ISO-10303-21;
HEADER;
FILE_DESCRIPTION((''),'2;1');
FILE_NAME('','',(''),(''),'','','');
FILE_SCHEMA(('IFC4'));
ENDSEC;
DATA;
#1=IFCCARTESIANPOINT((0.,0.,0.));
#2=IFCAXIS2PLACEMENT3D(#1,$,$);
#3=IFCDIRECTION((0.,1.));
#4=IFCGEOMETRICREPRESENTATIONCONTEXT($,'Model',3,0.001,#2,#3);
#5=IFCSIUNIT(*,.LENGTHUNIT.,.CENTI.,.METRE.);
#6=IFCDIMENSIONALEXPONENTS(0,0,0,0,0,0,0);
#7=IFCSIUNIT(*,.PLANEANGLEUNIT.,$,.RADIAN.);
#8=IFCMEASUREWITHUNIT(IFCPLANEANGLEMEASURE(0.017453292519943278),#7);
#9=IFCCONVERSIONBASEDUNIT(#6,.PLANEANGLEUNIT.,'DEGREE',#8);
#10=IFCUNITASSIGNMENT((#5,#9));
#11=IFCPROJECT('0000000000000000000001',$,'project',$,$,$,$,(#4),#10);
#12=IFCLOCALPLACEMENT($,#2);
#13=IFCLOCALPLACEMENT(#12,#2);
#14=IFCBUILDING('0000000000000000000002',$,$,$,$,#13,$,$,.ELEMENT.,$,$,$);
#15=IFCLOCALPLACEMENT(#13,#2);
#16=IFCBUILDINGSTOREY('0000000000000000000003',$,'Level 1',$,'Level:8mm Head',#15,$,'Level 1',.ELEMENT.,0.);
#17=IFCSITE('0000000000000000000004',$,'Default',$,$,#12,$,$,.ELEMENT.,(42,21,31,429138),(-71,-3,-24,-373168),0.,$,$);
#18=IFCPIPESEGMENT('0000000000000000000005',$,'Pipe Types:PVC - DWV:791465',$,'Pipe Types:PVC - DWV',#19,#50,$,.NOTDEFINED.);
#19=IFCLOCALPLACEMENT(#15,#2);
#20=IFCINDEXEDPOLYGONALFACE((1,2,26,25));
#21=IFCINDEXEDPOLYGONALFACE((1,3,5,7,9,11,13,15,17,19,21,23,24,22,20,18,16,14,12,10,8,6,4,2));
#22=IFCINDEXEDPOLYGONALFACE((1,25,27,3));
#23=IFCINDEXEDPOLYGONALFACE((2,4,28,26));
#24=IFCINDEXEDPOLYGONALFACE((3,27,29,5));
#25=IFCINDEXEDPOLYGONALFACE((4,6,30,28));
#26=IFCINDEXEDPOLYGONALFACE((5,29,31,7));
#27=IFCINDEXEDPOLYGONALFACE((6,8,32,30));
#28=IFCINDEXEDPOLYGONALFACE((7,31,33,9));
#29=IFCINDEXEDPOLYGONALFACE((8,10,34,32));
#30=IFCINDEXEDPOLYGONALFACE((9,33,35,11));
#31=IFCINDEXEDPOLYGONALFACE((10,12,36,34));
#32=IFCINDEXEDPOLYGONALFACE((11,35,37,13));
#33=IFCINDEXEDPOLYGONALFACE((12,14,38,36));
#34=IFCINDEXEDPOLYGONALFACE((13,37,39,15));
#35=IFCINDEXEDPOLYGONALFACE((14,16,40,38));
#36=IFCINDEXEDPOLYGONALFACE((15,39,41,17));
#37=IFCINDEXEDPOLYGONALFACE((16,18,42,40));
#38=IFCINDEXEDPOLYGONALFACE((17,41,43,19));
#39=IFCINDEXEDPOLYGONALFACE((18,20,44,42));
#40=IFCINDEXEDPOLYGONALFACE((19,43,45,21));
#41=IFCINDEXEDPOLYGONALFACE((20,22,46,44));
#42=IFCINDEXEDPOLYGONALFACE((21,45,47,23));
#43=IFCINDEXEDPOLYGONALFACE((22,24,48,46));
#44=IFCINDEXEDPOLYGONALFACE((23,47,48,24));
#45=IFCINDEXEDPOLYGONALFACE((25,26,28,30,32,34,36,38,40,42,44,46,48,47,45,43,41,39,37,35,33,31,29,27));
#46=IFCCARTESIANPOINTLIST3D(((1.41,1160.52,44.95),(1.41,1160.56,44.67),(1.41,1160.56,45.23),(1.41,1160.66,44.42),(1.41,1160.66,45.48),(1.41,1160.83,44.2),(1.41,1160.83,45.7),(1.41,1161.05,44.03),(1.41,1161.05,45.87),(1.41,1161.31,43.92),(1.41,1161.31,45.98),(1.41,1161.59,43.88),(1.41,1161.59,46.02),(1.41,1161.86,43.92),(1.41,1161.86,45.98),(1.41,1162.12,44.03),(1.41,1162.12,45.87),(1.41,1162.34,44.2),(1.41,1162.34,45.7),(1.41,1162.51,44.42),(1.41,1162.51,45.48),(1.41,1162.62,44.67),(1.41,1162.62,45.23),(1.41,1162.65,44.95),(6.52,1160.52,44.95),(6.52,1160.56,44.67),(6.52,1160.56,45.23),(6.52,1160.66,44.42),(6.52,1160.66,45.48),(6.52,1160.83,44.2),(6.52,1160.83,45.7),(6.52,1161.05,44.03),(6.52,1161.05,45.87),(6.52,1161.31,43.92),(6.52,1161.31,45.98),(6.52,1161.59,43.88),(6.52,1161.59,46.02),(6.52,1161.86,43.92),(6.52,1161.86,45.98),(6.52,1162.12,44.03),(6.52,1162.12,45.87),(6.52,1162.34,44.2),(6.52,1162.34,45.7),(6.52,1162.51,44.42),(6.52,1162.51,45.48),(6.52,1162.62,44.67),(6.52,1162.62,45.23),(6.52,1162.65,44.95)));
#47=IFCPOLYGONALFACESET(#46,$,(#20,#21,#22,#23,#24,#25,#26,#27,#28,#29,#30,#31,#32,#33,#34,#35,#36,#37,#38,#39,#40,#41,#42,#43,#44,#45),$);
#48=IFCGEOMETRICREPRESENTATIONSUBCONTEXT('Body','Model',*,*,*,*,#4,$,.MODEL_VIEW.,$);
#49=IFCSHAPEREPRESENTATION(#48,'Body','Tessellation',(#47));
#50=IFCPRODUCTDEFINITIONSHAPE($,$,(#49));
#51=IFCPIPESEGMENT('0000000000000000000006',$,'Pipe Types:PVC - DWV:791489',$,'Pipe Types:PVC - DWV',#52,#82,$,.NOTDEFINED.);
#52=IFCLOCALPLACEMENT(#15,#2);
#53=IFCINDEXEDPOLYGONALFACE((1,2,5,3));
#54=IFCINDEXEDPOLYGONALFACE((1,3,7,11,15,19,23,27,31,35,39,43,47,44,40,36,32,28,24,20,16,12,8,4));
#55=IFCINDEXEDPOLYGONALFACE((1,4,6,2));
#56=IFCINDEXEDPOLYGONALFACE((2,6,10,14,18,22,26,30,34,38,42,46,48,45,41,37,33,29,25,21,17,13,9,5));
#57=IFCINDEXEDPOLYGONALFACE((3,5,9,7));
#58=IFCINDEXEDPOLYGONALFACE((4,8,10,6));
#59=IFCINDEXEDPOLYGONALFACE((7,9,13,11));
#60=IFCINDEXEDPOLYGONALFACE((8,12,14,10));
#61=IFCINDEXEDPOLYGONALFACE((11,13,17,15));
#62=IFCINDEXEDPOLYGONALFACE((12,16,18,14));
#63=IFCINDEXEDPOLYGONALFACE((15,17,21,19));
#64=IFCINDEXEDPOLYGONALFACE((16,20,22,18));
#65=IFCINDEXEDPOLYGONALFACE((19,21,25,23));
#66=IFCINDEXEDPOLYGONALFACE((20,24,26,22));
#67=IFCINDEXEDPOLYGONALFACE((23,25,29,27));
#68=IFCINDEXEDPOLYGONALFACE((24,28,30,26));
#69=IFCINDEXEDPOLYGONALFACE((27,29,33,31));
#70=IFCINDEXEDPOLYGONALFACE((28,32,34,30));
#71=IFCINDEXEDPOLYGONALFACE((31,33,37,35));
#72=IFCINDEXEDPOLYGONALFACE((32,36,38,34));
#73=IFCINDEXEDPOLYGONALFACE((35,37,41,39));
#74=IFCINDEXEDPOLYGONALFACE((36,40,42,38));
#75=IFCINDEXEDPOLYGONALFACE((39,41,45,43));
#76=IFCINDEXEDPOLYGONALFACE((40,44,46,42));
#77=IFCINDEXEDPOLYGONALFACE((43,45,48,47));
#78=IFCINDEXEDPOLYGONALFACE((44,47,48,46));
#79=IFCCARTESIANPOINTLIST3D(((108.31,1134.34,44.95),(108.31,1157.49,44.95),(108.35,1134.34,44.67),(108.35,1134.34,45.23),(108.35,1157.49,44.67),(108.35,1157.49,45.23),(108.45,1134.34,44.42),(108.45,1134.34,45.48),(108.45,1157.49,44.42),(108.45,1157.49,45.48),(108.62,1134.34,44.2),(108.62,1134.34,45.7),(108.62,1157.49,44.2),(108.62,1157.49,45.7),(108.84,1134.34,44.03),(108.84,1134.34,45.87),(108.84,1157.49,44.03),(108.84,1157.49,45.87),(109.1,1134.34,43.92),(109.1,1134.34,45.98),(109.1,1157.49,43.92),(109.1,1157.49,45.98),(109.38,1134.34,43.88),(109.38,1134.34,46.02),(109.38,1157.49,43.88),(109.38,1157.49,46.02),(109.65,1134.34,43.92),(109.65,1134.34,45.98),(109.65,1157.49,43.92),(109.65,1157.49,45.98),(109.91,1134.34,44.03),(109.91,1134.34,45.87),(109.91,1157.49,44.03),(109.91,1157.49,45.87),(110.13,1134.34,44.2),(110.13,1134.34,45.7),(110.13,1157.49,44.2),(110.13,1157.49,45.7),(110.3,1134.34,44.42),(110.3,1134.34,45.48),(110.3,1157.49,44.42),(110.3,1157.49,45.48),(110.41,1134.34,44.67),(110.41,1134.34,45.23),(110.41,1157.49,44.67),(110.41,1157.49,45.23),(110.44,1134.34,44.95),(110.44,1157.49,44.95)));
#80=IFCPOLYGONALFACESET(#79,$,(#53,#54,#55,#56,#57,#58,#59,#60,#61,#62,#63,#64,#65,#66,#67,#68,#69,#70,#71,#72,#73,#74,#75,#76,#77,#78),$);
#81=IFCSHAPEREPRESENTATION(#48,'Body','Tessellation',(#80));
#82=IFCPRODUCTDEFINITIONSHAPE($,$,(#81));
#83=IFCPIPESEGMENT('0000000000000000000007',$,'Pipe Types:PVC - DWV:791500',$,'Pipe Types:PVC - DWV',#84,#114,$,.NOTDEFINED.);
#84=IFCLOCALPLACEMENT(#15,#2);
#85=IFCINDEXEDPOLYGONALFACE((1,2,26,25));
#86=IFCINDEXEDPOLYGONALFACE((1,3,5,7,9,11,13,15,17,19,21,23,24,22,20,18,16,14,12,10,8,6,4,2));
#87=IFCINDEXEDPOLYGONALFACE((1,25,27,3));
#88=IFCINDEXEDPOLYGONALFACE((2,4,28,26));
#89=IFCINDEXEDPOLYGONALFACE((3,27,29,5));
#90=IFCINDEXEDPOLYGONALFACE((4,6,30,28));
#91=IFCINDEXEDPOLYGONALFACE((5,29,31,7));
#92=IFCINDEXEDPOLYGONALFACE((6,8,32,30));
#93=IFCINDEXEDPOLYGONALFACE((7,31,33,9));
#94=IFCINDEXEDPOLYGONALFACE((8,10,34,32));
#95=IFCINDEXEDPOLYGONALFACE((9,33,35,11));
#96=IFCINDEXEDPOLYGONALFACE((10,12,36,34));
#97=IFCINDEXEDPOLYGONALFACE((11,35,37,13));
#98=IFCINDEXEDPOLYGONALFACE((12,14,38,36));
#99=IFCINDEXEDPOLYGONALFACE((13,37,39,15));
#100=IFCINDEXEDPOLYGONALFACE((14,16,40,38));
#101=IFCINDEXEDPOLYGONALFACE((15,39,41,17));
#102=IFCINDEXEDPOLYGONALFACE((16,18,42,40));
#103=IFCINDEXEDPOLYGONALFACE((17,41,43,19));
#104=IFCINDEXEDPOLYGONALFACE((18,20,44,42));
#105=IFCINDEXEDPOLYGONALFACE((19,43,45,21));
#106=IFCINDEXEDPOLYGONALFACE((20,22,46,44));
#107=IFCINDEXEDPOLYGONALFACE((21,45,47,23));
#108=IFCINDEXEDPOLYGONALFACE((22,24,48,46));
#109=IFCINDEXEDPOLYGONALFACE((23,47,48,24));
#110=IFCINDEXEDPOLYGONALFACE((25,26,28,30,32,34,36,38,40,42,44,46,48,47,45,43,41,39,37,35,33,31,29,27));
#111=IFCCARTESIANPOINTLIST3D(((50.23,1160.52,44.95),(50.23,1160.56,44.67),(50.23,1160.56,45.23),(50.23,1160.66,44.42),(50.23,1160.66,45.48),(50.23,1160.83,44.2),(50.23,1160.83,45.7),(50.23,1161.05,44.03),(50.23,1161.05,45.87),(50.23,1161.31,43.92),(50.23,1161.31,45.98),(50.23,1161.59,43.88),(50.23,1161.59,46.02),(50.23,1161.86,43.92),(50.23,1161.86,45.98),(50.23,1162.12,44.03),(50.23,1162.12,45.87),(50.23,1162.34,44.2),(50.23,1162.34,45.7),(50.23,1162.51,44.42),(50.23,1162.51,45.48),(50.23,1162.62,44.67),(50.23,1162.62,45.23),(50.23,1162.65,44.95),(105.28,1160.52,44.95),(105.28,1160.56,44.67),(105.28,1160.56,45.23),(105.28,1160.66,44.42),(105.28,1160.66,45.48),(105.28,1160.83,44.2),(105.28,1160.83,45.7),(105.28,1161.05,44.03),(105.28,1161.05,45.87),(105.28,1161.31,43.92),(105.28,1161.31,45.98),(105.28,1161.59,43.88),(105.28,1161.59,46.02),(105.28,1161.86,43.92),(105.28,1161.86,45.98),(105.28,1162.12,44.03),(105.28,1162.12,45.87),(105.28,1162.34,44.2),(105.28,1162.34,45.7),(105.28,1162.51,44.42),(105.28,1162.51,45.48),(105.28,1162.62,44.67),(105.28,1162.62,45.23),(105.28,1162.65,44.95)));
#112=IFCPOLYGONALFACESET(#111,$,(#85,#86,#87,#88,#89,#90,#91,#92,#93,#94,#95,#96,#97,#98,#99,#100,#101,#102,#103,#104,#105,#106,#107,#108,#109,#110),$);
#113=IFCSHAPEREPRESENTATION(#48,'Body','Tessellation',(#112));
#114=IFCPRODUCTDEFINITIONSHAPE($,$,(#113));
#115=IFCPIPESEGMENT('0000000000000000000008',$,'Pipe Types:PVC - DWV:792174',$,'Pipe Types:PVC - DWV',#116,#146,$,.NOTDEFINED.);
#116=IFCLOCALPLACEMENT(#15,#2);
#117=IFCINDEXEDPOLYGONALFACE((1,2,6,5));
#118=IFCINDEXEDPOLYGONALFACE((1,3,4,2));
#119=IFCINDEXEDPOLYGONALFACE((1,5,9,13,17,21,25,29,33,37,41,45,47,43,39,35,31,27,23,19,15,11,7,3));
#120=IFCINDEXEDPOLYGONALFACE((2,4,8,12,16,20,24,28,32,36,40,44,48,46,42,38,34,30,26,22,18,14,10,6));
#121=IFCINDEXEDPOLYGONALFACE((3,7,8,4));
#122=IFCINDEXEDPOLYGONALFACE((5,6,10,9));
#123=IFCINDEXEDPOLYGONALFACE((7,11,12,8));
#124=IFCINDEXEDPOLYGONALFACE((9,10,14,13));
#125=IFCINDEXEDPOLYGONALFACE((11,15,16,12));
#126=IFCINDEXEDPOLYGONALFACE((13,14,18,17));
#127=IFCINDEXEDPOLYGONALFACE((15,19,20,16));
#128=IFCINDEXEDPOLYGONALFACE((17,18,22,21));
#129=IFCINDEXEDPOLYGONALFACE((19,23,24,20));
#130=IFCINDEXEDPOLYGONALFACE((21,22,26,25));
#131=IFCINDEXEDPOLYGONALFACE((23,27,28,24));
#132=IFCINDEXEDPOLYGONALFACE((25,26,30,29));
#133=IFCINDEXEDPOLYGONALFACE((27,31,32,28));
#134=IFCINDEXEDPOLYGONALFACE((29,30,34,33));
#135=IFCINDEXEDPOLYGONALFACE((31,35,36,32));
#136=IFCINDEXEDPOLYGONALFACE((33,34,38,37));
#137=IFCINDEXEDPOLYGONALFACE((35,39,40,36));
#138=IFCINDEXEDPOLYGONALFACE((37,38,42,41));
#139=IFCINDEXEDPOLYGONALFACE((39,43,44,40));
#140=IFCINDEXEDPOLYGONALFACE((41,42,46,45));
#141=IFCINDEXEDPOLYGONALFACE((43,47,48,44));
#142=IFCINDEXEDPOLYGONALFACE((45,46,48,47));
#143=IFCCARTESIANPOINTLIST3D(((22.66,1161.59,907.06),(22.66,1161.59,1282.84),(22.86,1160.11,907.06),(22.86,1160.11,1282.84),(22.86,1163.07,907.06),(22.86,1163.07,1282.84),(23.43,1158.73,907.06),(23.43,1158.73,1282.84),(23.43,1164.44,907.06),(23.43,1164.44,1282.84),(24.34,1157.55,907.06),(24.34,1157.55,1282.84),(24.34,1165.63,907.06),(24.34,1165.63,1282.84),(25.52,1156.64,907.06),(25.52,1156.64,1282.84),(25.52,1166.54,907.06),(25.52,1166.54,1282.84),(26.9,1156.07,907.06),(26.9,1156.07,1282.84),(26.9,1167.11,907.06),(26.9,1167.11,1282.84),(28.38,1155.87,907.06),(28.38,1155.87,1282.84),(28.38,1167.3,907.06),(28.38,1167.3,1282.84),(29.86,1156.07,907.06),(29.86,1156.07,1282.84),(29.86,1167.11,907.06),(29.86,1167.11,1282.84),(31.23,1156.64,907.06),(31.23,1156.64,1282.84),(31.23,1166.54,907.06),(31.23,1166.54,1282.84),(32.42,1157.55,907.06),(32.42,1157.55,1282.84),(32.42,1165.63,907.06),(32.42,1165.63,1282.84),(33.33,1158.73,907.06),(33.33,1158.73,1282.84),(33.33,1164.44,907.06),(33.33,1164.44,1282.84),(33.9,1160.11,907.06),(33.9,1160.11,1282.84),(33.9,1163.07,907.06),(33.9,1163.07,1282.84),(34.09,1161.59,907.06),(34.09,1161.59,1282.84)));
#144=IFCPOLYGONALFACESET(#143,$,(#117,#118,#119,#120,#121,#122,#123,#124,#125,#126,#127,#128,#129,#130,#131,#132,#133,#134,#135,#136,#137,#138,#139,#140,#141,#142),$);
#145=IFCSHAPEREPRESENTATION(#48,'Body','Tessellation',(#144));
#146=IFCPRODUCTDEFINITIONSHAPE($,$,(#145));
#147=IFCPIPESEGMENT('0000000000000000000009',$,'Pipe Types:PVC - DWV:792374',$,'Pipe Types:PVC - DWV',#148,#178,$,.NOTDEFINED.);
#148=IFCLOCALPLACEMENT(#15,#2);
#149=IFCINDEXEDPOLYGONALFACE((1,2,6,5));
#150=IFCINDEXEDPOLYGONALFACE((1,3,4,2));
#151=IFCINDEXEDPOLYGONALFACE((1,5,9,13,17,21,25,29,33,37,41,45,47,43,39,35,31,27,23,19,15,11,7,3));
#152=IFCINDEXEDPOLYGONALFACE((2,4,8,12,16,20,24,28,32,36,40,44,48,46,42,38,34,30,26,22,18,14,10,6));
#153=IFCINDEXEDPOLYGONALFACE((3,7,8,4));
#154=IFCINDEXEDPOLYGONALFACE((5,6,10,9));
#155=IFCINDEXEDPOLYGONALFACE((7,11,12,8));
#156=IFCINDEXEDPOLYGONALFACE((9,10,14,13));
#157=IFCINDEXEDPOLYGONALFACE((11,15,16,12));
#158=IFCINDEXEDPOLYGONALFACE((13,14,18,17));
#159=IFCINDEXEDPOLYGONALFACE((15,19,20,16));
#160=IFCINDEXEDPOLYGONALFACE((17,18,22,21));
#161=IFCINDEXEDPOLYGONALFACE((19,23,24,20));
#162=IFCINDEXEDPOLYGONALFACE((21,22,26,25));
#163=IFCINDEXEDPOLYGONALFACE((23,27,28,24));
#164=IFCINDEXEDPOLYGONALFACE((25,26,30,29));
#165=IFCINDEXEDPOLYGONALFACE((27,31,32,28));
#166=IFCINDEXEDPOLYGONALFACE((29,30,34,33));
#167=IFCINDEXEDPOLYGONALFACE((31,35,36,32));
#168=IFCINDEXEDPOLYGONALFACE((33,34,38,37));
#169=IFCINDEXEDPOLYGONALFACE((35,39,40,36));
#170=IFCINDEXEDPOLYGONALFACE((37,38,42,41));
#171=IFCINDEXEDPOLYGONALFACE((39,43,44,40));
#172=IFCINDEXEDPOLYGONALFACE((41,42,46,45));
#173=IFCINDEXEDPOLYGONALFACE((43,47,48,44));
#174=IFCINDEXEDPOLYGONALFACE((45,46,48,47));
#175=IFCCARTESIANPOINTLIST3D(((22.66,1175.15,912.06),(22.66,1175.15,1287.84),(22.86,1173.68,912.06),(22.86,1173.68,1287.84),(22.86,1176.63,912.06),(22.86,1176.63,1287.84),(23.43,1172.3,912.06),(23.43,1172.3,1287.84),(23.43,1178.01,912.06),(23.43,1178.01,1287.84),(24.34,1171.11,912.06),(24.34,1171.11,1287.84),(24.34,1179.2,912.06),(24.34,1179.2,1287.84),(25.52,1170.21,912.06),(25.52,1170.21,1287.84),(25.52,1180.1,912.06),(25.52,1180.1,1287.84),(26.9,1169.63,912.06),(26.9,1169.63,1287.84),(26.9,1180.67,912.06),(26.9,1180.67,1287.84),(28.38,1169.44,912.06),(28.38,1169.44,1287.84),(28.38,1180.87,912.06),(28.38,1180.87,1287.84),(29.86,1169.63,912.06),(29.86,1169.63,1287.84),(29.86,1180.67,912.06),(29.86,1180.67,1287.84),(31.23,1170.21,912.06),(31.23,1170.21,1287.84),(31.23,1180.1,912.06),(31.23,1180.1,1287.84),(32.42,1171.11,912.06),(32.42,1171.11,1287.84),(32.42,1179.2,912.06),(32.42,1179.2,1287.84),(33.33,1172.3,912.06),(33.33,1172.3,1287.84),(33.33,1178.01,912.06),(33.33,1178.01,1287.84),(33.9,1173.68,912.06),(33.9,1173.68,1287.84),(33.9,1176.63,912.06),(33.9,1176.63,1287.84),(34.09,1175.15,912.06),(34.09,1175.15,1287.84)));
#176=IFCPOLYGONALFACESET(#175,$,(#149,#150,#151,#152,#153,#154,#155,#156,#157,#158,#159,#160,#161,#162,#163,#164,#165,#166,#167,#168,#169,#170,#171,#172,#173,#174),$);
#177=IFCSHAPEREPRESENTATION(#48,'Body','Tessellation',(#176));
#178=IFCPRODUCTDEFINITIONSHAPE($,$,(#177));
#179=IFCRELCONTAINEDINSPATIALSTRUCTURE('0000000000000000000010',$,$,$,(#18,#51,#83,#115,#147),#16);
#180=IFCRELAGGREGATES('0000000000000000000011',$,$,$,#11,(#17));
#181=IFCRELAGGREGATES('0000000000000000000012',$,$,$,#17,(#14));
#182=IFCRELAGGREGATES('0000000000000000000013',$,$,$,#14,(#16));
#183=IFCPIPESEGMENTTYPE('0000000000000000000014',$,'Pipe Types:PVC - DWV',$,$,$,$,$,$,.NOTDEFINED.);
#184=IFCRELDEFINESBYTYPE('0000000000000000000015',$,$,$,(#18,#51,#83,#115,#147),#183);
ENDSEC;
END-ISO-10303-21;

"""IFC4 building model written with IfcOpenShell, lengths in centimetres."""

from ifc_helpers import new_model, entity, si_unit, converted_unit, direction, frame, origin, place, context, subcontext, project, spatial, arc, indexed_curve, outline, extrude, type_object, element, save


model = new_model("IFC4")

# Units and contexts
model_context = context("Model", 3, precision=0.001, world=origin(), true_north=direction((0.0, 1.0)))
body_context = subcontext(model_context, "Body", "Model", "MODEL_VIEW")
ifc_project = project(units=[si_unit("LENGTHUNIT", "METRE", prefix="CENTI"), converted_unit("PLANEANGLEUNIT", "DEGREE", entity("IfcPlaneAngleMeasure", 0.017453292519943278), si_unit("PLANEANGLEUNIT", "RADIAN"), dimensions=[0, 0, 0, 0, 0, 0, 0])], contexts=[model_context])

# Site, building, storey
site_placement = place(None, origin())
site = spatial("IfcSite", under=ifc_project, at=site_placement, Name="Default", CompositionType="ELEMENT", RefLatitude=(42, 21, 31, 429138), RefLongitude=(-71, -3, -24, -373168), RefElevation=0.0)
building_placement = place(site_placement, origin())
building = spatial("IfcBuilding", under=site, at=building_placement, CompositionType="ELEMENT")
storey_placement = place(building_placement, origin())
storey = spatial("IfcBuildingStorey", under=building, at=storey_placement, Name="Level 1", ObjectType="Level:8mm Head", LongName="Level 1", CompositionType="ELEMENT", Elevation=0.0)

# Pipe segments
pipe_segment_type = type_object("IfcPipeSegmentType", Name="Pipe Types:PVC - DWV", PredefinedType="NOTDEFINED")
pipe_segment_1_placement = place(storey_placement, origin())
element("IfcPipeSegment", 1, at=pipe_segment_1_placement, inside=storey, type_object=pipe_segment_type, Name="Pipe Types:PVC - DWV:791465", ObjectType="Pipe Types:PVC - DWV", PredefinedType="NOTDEFINED", context=body_context, shape_type="SweptSolid", body=[
    extrude(outline(indexed_curve([(1.07, 0.0), (0.75, 0.75), (0.0, 1.07), (-0.75, 0.75), (-1.07, 0.0), (-0.75, -0.75), (0.0, -1.07), (0.75, -0.75)], segments=[arc(1, 2, 3), arc(3, 4, 5), arc(5, 6, 7), arc(7, 8, 1)], self_intersect=False)), frame((1.41, 1161.59, 44.95), z_axis=(1.0, 0.0, 0.0), x_axis=(0.0, 1.0, 0.0)), (0.0, 0.0, 1.0), 5.11),
])
pipe_segment_2_placement = place(storey_placement, origin())
element("IfcPipeSegment", 2, at=pipe_segment_2_placement, inside=storey, type_object=pipe_segment_type, Name="Pipe Types:PVC - DWV:791489", ObjectType="Pipe Types:PVC - DWV", PredefinedType="NOTDEFINED", context=body_context, shape_type="SweptSolid", body=[
    extrude(outline(indexed_curve([(1.07, 0.0), (0.75, 0.75), (0.0, 1.07), (-0.75, 0.75), (-1.07, 0.0), (-0.75, -0.75), (0.0, -1.07), (0.75, -0.75)], segments=[arc(1, 2, 3), arc(3, 4, 5), arc(5, 6, 7), arc(7, 8, 1)], self_intersect=False)), frame((109.38, 1134.34, 44.95), z_axis=(0.0, 1.0, 0.0), x_axis=(1.0, 0.0, 0.0)), (0.0, 0.0, 1.0), 23.14),
])
pipe_segment_3_placement = place(storey_placement, origin())
element("IfcPipeSegment", 3, at=pipe_segment_3_placement, inside=storey, type_object=pipe_segment_type, Name="Pipe Types:PVC - DWV:791500", ObjectType="Pipe Types:PVC - DWV", PredefinedType="NOTDEFINED", context=body_context, shape_type="SweptSolid", body=[
    extrude(outline(indexed_curve([(1.07, 0.0), (0.75, 0.75), (0.0, 1.07), (-0.75, 0.75), (-1.07, 0.0), (-0.75, -0.75), (0.0, -1.07), (0.75, -0.75)], segments=[arc(1, 2, 3), arc(3, 4, 5), arc(5, 6, 7), arc(7, 8, 1)], self_intersect=False)), frame((50.23, 1161.59, 44.95), z_axis=(1.0, 0.0, 0.0), x_axis=(0.0, -1.0, 0.0)), (0.0, 0.0, 1.0), 55.04),
])
pipe_segment_4_placement = place(storey_placement, origin())
element("IfcPipeSegment", 4, at=pipe_segment_4_placement, inside=storey, type_object=pipe_segment_type, Name="Pipe Types:PVC - DWV:792174", ObjectType="Pipe Types:PVC - DWV", PredefinedType="NOTDEFINED", context=body_context, shape_type="SweptSolid", body=[
    extrude(outline(indexed_curve([(5.72, 0.0), (4.04, 4.04), (0.0, 5.71), (-4.04, 4.04), (-5.71, 0.0), (-4.04, -4.04), (0.0, -5.71), (4.04, -4.04)], segments=[arc(1, 2, 3), arc(3, 4, 5), arc(5, 6, 7), arc(7, 8, 1)], self_intersect=False)), frame((28.38, 1161.59, 907.06), z_axis=(0.0, 0.0, 1.0), x_axis=(-1.0, 0.0, 0.0)), (0.0, 0.0, 1.0), 375.78),
])
pipe_segment_5_placement = place(storey_placement, origin())
element("IfcPipeSegment", 5, at=pipe_segment_5_placement, inside=storey, type_object=pipe_segment_type, Name="Pipe Types:PVC - DWV:792374", ObjectType="Pipe Types:PVC - DWV", PredefinedType="NOTDEFINED", context=body_context, shape_type="SweptSolid", body=[
    extrude(outline(indexed_curve([(5.72, 0.0), (4.04, 4.04), (0.0, 5.71), (-4.04, 4.04), (-5.71, 0.0), (-4.04, -4.04), (0.0, -5.71), (4.04, -4.04)], segments=[arc(1, 2, 3), arc(3, 4, 5), arc(5, 6, 7), arc(7, 8, 1)], self_intersect=False)), frame((28.38, 1175.15, 912.06), z_axis=(0.0, 0.0, 1.0), x_axis=(-1.0, 0.0, 0.0)), (0.0, 0.0, 1.0), 375.78),
])

save(model, "model.ifc")
